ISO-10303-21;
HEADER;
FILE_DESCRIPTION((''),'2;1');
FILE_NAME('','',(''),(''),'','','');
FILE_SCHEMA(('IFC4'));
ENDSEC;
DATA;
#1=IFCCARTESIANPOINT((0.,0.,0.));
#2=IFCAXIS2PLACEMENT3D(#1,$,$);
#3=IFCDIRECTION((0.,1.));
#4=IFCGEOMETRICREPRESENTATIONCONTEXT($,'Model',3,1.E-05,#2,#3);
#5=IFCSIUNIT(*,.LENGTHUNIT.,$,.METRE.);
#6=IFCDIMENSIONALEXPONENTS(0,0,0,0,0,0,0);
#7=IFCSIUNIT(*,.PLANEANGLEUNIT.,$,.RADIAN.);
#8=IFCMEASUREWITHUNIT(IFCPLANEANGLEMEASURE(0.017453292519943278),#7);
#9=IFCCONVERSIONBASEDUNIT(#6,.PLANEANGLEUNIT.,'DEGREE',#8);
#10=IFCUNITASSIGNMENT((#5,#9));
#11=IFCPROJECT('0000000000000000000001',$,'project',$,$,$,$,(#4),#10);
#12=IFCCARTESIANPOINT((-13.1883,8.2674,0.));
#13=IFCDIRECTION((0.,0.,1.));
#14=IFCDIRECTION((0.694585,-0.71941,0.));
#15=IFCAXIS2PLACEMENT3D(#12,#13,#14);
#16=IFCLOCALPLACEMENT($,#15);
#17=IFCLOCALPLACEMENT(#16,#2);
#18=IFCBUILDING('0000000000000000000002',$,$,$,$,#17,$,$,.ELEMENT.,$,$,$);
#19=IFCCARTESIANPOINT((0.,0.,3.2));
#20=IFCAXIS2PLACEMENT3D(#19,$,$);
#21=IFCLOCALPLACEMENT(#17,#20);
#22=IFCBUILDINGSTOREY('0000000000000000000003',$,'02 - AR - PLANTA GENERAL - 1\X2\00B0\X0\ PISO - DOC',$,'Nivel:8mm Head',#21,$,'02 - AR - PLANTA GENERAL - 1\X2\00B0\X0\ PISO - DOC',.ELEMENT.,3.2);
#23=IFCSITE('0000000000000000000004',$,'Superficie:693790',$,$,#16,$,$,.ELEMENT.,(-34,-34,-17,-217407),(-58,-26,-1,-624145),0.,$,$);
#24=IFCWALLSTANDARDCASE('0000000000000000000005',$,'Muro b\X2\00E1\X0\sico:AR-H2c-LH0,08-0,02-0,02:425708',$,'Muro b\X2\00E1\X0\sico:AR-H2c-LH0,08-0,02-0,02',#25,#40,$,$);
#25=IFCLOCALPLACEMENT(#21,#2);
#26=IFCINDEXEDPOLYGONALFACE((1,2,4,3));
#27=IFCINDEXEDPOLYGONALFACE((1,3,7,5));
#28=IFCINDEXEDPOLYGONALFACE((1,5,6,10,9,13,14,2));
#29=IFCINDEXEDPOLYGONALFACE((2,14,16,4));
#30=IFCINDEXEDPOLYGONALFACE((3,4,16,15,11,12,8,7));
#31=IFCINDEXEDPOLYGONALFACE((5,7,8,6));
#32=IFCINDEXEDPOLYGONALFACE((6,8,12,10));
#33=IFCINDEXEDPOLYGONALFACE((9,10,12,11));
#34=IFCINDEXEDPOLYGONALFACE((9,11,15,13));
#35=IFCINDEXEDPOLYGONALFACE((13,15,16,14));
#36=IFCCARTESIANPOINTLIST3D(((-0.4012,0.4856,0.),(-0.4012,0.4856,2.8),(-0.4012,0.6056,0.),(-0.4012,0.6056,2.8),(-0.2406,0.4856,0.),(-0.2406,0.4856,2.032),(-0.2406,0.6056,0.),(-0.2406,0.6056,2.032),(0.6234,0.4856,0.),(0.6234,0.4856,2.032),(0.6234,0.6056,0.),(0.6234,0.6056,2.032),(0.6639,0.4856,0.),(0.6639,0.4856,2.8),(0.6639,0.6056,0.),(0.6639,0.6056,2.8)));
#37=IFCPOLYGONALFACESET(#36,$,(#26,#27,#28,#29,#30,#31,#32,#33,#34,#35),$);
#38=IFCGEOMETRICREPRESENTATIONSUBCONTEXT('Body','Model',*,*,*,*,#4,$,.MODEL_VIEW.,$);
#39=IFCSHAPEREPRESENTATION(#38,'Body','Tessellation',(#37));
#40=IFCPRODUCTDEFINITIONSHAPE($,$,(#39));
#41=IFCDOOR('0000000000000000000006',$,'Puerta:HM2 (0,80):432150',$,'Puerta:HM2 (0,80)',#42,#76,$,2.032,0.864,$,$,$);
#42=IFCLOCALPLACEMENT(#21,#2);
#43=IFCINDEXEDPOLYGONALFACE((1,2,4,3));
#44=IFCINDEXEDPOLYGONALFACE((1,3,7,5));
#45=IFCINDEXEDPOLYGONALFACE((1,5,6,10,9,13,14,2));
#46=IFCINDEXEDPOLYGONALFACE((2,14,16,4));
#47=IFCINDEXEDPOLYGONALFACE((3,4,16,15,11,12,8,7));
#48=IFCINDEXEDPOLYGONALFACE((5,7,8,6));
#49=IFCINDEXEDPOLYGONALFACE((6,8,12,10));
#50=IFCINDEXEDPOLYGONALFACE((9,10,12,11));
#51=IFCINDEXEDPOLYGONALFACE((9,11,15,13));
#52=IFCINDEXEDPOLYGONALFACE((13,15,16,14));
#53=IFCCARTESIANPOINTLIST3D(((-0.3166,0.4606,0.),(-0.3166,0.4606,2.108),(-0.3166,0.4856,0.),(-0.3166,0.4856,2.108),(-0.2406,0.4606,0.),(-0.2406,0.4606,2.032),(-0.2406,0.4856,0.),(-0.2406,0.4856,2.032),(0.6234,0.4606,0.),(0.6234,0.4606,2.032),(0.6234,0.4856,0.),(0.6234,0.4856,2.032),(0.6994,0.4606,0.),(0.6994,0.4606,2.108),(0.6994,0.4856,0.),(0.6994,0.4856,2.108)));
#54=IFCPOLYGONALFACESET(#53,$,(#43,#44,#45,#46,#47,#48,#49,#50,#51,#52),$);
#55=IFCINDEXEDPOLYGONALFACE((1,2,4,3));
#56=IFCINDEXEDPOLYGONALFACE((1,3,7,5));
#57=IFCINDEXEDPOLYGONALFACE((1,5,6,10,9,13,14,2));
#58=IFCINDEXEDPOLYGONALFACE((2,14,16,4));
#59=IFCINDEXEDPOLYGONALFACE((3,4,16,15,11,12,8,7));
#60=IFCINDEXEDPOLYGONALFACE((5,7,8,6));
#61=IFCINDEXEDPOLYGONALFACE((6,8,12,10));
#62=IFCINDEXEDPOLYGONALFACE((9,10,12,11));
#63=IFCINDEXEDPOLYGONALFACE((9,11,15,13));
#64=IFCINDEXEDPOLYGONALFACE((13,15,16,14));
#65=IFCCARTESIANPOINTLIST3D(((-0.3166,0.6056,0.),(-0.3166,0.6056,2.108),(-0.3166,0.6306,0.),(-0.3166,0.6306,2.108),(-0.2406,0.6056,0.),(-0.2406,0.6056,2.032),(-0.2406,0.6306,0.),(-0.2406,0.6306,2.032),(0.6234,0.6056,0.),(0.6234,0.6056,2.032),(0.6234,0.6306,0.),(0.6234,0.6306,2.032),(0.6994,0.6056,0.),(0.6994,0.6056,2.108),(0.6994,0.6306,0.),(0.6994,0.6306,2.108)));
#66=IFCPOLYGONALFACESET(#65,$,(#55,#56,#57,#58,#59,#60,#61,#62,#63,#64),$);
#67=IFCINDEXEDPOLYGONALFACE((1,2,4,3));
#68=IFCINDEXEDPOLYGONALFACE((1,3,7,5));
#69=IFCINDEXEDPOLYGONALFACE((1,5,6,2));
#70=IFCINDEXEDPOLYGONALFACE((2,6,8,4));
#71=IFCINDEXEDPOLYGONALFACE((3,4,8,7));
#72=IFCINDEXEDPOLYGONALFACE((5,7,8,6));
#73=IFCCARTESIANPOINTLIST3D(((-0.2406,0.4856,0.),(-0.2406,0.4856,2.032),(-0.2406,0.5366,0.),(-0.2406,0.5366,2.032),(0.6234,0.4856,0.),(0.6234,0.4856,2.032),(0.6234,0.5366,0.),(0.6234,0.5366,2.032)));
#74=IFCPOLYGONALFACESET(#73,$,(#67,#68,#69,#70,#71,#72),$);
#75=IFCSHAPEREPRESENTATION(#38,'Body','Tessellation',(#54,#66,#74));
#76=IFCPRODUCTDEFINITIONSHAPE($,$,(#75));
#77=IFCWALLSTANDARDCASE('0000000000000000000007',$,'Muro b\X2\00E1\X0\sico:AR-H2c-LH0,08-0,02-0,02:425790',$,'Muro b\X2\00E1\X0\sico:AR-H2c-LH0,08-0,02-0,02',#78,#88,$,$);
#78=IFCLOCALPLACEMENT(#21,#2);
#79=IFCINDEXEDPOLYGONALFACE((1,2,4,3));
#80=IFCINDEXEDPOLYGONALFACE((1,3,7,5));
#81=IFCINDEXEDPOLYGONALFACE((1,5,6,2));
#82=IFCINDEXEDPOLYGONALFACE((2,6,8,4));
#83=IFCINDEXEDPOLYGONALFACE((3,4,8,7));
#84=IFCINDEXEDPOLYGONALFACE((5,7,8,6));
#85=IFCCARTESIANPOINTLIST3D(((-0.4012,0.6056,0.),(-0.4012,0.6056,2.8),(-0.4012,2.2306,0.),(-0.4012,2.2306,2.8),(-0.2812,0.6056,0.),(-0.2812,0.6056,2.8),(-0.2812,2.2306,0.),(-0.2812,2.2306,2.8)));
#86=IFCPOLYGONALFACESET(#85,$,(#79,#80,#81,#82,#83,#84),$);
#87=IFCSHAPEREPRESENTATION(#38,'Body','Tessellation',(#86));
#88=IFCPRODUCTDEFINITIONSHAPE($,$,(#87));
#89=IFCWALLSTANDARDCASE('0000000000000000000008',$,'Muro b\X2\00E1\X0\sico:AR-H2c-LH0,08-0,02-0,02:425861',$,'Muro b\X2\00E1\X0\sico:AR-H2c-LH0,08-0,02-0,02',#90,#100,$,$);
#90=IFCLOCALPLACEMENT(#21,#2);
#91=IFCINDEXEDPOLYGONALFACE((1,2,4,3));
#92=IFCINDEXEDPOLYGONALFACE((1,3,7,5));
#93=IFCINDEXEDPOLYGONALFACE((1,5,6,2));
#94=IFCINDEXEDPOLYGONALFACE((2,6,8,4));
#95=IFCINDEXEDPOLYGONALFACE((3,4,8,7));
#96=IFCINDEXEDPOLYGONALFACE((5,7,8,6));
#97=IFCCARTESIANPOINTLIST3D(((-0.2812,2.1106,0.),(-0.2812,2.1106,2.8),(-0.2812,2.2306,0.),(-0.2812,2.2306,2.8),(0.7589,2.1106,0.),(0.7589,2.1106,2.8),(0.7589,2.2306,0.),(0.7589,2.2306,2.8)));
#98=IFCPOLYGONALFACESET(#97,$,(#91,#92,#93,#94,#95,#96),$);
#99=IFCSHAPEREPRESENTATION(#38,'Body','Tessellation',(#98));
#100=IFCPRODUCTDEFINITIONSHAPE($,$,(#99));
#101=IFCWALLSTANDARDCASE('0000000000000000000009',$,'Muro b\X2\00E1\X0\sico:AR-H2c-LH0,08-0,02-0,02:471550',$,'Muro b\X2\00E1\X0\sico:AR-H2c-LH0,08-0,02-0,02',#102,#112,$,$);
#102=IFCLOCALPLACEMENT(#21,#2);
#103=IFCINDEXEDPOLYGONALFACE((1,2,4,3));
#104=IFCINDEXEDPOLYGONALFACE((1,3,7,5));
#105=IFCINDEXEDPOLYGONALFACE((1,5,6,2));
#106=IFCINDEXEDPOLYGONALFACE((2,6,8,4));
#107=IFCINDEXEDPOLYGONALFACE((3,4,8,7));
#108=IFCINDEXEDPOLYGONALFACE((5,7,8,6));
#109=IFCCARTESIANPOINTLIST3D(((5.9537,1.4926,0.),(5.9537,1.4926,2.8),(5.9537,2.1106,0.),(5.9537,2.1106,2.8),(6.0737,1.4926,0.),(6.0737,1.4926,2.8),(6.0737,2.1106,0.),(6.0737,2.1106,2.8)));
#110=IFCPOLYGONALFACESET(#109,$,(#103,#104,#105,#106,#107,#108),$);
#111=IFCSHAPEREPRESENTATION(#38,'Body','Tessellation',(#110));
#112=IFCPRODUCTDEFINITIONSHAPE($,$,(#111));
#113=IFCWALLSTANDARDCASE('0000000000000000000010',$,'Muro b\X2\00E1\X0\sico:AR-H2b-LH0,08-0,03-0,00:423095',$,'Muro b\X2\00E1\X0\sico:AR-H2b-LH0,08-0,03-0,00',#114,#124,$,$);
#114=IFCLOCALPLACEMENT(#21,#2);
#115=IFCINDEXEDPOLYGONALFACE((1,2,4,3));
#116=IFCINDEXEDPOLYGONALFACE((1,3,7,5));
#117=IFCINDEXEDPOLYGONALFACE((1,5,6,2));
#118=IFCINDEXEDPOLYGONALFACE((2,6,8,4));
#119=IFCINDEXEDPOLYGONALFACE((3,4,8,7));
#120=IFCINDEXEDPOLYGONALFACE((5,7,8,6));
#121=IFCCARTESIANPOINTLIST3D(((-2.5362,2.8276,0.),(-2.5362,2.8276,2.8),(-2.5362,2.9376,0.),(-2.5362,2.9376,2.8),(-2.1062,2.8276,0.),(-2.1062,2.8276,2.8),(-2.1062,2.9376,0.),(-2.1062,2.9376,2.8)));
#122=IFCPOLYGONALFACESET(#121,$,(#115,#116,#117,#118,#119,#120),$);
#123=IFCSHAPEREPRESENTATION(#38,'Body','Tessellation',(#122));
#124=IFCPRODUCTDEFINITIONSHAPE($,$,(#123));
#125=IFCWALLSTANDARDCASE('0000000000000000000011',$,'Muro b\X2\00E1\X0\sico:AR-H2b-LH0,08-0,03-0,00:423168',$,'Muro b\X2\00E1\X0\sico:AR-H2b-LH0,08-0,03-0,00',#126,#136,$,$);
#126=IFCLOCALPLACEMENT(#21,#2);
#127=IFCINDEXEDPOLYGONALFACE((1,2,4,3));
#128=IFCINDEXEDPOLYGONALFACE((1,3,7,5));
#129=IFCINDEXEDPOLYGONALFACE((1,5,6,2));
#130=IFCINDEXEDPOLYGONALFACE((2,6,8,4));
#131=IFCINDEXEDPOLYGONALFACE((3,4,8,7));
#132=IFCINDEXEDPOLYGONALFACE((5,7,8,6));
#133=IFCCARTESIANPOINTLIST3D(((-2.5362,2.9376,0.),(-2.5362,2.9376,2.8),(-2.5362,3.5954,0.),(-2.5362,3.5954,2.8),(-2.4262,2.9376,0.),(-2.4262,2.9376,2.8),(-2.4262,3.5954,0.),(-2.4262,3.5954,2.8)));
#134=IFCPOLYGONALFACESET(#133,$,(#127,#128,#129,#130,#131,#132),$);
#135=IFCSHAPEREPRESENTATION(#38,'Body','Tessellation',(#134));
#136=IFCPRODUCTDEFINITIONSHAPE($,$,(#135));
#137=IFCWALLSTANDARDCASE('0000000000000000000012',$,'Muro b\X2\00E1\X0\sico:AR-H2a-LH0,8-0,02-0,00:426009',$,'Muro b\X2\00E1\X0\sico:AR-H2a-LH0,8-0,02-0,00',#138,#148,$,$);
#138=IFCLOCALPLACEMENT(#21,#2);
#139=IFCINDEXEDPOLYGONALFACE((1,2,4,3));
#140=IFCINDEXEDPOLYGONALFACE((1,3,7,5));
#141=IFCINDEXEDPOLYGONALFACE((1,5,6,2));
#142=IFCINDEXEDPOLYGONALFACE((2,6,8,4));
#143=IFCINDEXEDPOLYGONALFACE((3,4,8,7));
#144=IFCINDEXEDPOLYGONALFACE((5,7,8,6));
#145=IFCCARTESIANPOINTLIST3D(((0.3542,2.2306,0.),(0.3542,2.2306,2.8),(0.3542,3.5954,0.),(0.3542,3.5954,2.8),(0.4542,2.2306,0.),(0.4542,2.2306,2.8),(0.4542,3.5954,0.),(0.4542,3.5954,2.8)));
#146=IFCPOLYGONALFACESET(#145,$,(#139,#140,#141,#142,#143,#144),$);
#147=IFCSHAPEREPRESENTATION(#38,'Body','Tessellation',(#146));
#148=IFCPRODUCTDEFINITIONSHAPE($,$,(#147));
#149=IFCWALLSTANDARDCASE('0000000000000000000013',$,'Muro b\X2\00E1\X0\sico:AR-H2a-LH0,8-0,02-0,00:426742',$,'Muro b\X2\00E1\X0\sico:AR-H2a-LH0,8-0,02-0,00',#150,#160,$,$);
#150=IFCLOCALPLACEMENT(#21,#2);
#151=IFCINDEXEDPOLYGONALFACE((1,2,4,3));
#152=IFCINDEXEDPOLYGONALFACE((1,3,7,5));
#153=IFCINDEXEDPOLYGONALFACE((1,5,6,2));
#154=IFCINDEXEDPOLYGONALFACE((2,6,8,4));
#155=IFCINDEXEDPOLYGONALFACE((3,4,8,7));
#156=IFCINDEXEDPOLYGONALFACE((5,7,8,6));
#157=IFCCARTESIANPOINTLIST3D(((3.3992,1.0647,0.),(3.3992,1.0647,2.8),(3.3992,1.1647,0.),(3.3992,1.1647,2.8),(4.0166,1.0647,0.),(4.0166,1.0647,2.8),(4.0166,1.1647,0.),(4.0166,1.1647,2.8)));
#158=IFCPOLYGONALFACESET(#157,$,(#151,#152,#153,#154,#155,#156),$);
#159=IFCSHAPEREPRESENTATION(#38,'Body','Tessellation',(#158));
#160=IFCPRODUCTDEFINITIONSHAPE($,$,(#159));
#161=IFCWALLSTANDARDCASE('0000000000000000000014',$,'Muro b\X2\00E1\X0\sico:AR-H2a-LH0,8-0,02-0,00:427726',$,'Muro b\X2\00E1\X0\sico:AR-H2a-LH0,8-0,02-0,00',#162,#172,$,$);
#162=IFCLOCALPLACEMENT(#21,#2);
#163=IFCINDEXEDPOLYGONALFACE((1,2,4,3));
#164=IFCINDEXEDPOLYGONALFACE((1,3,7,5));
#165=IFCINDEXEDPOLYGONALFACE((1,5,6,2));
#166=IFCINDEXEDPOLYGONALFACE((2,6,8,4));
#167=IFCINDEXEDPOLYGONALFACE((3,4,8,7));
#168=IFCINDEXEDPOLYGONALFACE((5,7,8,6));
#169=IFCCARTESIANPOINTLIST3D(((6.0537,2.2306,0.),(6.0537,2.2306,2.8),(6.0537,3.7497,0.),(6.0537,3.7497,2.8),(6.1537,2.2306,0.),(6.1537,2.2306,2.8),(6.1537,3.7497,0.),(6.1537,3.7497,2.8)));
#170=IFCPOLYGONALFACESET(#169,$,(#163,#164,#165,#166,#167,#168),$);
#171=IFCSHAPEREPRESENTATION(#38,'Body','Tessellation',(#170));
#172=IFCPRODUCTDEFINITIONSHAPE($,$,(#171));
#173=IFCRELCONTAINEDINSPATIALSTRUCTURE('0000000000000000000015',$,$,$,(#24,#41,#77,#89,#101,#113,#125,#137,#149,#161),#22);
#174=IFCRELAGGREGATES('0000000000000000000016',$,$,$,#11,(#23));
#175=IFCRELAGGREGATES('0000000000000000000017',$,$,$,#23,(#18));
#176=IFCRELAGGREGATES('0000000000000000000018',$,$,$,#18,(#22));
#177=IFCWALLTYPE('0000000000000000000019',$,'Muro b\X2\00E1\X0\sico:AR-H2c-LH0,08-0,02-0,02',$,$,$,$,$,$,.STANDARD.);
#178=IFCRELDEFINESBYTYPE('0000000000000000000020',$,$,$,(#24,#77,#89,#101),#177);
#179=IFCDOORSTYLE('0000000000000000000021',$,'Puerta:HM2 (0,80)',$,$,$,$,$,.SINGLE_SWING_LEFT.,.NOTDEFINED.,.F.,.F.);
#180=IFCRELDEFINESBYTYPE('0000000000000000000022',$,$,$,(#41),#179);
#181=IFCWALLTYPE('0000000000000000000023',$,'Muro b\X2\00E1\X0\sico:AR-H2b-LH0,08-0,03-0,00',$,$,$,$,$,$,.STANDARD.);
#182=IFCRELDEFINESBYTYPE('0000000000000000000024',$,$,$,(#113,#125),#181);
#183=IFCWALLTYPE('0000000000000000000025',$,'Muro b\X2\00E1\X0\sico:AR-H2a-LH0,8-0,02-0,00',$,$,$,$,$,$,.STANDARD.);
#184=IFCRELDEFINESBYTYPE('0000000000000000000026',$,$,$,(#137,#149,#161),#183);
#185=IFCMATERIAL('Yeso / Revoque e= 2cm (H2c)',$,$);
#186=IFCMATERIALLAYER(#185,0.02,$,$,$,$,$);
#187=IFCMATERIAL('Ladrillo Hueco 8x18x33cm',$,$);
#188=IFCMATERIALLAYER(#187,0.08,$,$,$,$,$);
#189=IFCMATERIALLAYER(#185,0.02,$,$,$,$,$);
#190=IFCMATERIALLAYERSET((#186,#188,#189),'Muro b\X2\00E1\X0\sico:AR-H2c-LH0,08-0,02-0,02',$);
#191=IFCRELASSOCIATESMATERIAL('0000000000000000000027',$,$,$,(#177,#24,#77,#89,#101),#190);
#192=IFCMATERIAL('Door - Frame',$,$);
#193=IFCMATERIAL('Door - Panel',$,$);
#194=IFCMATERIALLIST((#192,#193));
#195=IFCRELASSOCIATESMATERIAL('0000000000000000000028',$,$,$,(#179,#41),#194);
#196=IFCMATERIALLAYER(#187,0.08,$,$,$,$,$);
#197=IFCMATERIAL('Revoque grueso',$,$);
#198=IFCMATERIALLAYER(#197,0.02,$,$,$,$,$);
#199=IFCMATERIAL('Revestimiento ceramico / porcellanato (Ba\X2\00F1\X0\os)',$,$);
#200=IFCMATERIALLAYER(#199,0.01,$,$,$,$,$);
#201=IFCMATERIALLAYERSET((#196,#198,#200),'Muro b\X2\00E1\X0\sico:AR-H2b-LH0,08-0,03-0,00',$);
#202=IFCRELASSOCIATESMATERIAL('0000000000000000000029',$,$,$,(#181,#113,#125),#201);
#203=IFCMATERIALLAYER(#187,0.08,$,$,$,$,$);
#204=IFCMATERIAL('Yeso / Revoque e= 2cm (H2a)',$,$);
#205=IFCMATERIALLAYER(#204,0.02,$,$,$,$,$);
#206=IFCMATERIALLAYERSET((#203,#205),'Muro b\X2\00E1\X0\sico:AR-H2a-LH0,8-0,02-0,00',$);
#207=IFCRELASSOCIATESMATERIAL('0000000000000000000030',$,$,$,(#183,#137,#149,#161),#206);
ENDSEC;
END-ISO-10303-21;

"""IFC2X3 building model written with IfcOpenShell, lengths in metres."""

from ifc_helpers import new_model, entity, si_unit, converted_unit, direction, frame, frame_2d, origin, origin_2d_with_axis, place, context, subcontext, project, spatial, polyline, rectangle, outline, extrude, source, transform, mapped, material, material_list, layer, layer_set, layer_usage, type_object, type_shapes, element, fill, save


model = new_model("IFC2X3")

# Units and contexts
model_context = context("Model", 3, precision=1e-05, world=origin(), true_north=direction((0.0, 1.0)))
body_context = subcontext(model_context, "Body", "Model", "MODEL_VIEW")
ifc_project = project(units=[si_unit("LENGTHUNIT", "METRE"), converted_unit("PLANEANGLEUNIT", "DEGREE", entity("IfcPlaneAngleMeasure", 0.017453292519943278), si_unit("PLANEANGLEUNIT", "RADIAN"), dimensions=[0, 0, 0, 0, 0, 0, 0])], contexts=[model_context])

# Site, building, storey
site_placement = place(None, frame((-13.1883, 8.2674, 0.0), z_axis=(0.0, 0.0, 1.0), x_axis=(0.694585, -0.71941, 0.0)))
site = spatial("IfcSite", under=ifc_project, at=site_placement, Name="Superficie:693790", CompositionType="ELEMENT", RefLatitude=(-34, -34, -17, -217407), RefLongitude=(-58, -26, -1, -624145), RefElevation=0.0)
building_placement = place(site_placement, origin())
building = spatial("IfcBuilding", under=site, at=building_placement, CompositionType="ELEMENT")
storey_placement = place(building_placement, frame((0.0, 0.0, 3.2)))
storey = spatial("IfcBuildingStorey", under=building, at=storey_placement, Name="02 - AR - PLANTA GENERAL - 1° PISO - DOC", ObjectType="Nivel:8mm Head", LongName="02 - AR - PLANTA GENERAL - 1° PISO - DOC", CompositionType="ELEMENT", Elevation=3.2)

# Wall, opening, door
ifc_material_1 = material(Name="Yeso / Revoque e= 2cm (H2c)")
ifc_layer_1 = layer(ifc_material_1, 0.02)
ifc_material_2 = material(Name="Ladrillo Hueco 8x18x33cm")
ifc_layer_2 = layer(ifc_material_2, 0.08)
ifc_layer_3 = layer(ifc_material_1, 0.02)
ifc_layer_set_1 = layer_set([ifc_layer_1, ifc_layer_2, ifc_layer_3], Name="Muro básico:AR-H2c-LH0,08-0,02-0,02")
ifc_layer_usage_1 = layer_usage(ifc_layer_set_1, "AXIS2", "NEGATIVE", 0.06)
wall_type_1 = type_object("IfcWallType", Name="Muro básico:AR-H2c-LH0,08-0,02-0,02", PredefinedType="STANDARD", material=ifc_layer_set_1)
wall_1_placement = place(storey_placement, frame((0.6639, 0.5456, 0.0), z_axis=(0.0, 0.0, 1.0), x_axis=(-1.0, 0.0, 0.0)))
wall_1 = element("IfcWallStandardCase", 1, at=wall_1_placement, inside=storey, type_object=wall_type_1, material=ifc_layer_usage_1, Name="Muro básico:AR-H2c-LH0,08-0,02-0,02:425708", ObjectType="Muro básico:AR-H2c-LH0,08-0,02-0,02", context=body_context, shape_type="SweptSolid", body=[
    extrude(rectangle(XDim=1.0652, YDim=0.12, at=frame_2d((0.5326, 0.0), x_axis=(1.0, 0.0))), origin(), (0.0, 0.0, 1.0), 2.8),
])
opening_1_placement = place(wall_1_placement, frame((0.0406, -0.06, 0.0)))
opening_1 = element("IfcOpeningElement", 2, at=opening_1_placement, cuts=wall_1, ObjectType="Opening", context=body_context, shape_type="SweptSolid", body=[
    extrude(rectangle(XDim=0.864, YDim=2.032, at=frame_2d((1.016, 0.432), x_axis=(0.0, -1.0))), frame((0.0, 0.0, 0.0), z_axis=(0.0, 1.0, 0.0), x_axis=(0.0, 0.0, 1.0)), (0.0, 0.0, 1.0), 0.12),
])
ifc_material_3 = material(Name="Door - Frame")
ifc_material_4 = material(Name="Door - Panel")
ifc_material_list = material_list([ifc_material_3, ifc_material_4])
door_style = type_object("IfcDoorStyle", Name="Puerta:HM2 (0,80)", ConstructionType="NOTDEFINED", OperationType="SINGLE_SWING_LEFT", ParameterTakesPrecedence=False, Sizeable=False, material=ifc_material_list)
shared_shape_1 = source(origin(), body_context, "Body", "SweptSolid", [
    extrude(outline(polyline([(-0.508, -1.073), (0.508, -1.073), (0.508, 1.035), (0.432, 1.035), (0.432, -0.997), (-0.432, -0.997), (-0.432, 1.035), (-0.508, 1.035), (-0.508, -1.073)])), frame((0.432, 0.145, 1.035), z_axis=(0.0, -1.0, 0.0), x_axis=(-1.0, 0.0, 0.0)), (0.0, 0.0, 1.0), 0.025),
    extrude(outline(polyline([(-1.073, -0.508), (1.035, -0.508), (1.035, -0.432), (-0.997, -0.432), (-0.997, 0.432), (1.035, 0.432), (1.035, 0.508), (-1.073, 0.508), (-1.073, -0.508)])), frame((0.432, 0.0, 1.035), z_axis=(0.0, -1.0, 0.0), x_axis=(0.0, 0.0, -1.0)), (0.0, 0.0, 1.0), 0.025),
    extrude(rectangle(XDim=0.864, YDim=0.051, at=origin_2d_with_axis()), frame((0.432, 0.0945, 0.0)), (0.0, 0.0, 1.0), 2.032),
])
type_shapes(door_style, [shared_shape_1])
door_placement = place(opening_1_placement, origin())
door = element("IfcDoor", 3, at=door_placement, inside=storey, type_object=door_style, material=ifc_material_list, Name="Puerta:HM2 (0,80):432150", ObjectType="Puerta:HM2 (0,80)", OverallHeight=2.032, OverallWidth=0.864, context=body_context, shape_type="MappedRepresentation", body=[
    mapped(shared_shape_1, transform((0.0, 0.0, 0.0), scale=1.0)),
])
fill(opening_1, door)

# Walls
ifc_layer_usage_2 = layer_usage(ifc_layer_set_1, "AXIS2", "NEGATIVE", 0.06)
wall_2_placement = place(storey_placement, frame((-0.3412, 0.6056, 0.0), z_axis=(0.0, 0.0, 1.0), x_axis=(0.0, 1.0, 0.0)))
element("IfcWallStandardCase", 4, at=wall_2_placement, inside=storey, type_object=wall_type_1, material=ifc_layer_usage_2, Name="Muro básico:AR-H2c-LH0,08-0,02-0,02:425790", ObjectType="Muro básico:AR-H2c-LH0,08-0,02-0,02", context=body_context, shape_type="SweptSolid", body=[
    extrude(rectangle(XDim=1.625, YDim=0.12, at=frame_2d((0.8125, 0.0), x_axis=(-1.0, 0.0))), origin(), (0.0, 0.0, 1.0), 2.8),
])
ifc_layer_usage_3 = layer_usage(ifc_layer_set_1, "AXIS2", "NEGATIVE", 0.06)
wall_3_placement = place(storey_placement, frame((-0.2812, 2.1706, 0.0)))
element("IfcWallStandardCase", 5, at=wall_3_placement, inside=storey, type_object=wall_type_1, material=ifc_layer_usage_3, Name="Muro básico:AR-H2c-LH0,08-0,02-0,02:425861", ObjectType="Muro básico:AR-H2c-LH0,08-0,02-0,02", context=body_context, shape_type="SweptSolid", body=[
    extrude(rectangle(XDim=1.0402, YDim=0.12, at=frame_2d((0.5201, 0.0), x_axis=(-1.0, 0.0))), origin(), (0.0, 0.0, 1.0), 2.8),
])
ifc_layer_usage_4 = layer_usage(ifc_layer_set_1, "AXIS2", "POSITIVE", -0.06)
wall_4_placement = place(storey_placement, frame((6.0137, 2.1106, 0.0), z_axis=(0.0, 0.0, 1.0), x_axis=(0.0, -1.0, 0.0)))
element("IfcWallStandardCase", 6, at=wall_4_placement, inside=storey, type_object=wall_type_1, material=ifc_layer_usage_4, Name="Muro básico:AR-H2c-LH0,08-0,02-0,02:471550", ObjectType="Muro básico:AR-H2c-LH0,08-0,02-0,02", context=body_context, shape_type="SweptSolid", body=[
    extrude(rectangle(XDim=0.6179, YDim=0.12, at=frame_2d((0.309, 0.0), x_axis=(-1.0, 0.0))), origin(), (0.0, 0.0, 1.0), 2.8),
])
ifc_layer_4 = layer(ifc_material_2, 0.08)
ifc_material_5 = material(Name="Revoque grueso")
ifc_layer_5 = layer(ifc_material_5, 0.02)
ifc_material_6 = material(Name="Revestimiento ceramico / porcellanato (Baños)")
ifc_layer_6 = layer(ifc_material_6, 0.01)
ifc_layer_set_2 = layer_set([ifc_layer_4, ifc_layer_5, ifc_layer_6], Name="Muro básico:AR-H2b-LH0,08-0,03-0,00")
ifc_layer_usage_5 = layer_usage(ifc_layer_set_2, "AXIS2", "POSITIVE", -0.055)
wall_type_2 = type_object("IfcWallType", Name="Muro básico:AR-H2b-LH0,08-0,03-0,00", PredefinedType="STANDARD", material=ifc_layer_set_2)
wall_5_placement = place(storey_placement, frame((-2.1062, 2.8826, 0.0), z_axis=(0.0, 0.0, 1.0), x_axis=(-1.0, 0.0, 0.0)))
element("IfcWallStandardCase", 7, at=wall_5_placement, inside=storey, type_object=wall_type_2, material=ifc_layer_usage_5, Name="Muro básico:AR-H2b-LH0,08-0,03-0,00:423095", ObjectType="Muro básico:AR-H2b-LH0,08-0,03-0,00", context=body_context, shape_type="SweptSolid", body=[
    extrude(rectangle(XDim=0.43, YDim=0.11, at=frame_2d((0.215, 0.0), x_axis=(-1.0, 0.0))), origin(), (0.0, 0.0, 1.0), 2.8),
])
ifc_layer_usage_6 = layer_usage(ifc_layer_set_2, "AXIS2", "POSITIVE", -0.055)
wall_6_placement = place(storey_placement, frame((-2.4812, 2.9376, 0.0), z_axis=(0.0, 0.0, 1.0), x_axis=(0.0, 1.0, 0.0)))
element("IfcWallStandardCase", 8, at=wall_6_placement, inside=storey, type_object=wall_type_2, material=ifc_layer_usage_6, Name="Muro básico:AR-H2b-LH0,08-0,03-0,00:423168", ObjectType="Muro básico:AR-H2b-LH0,08-0,03-0,00", context=body_context, shape_type="SweptSolid", body=[
    extrude(rectangle(XDim=0.6578, YDim=0.11, at=frame_2d((0.3289, 0.0), x_axis=(-1.0, 0.0))), origin(), (0.0, 0.0, 1.0), 2.8),
])
ifc_layer_7 = layer(ifc_material_2, 0.08)
ifc_material_7 = material(Name="Yeso / Revoque e= 2cm (H2a)")
ifc_layer_8 = layer(ifc_material_7, 0.02)
ifc_layer_set_3 = layer_set([ifc_layer_7, ifc_layer_8], Name="Muro básico:AR-H2a-LH0,8-0,02-0,00")
ifc_layer_usage_7 = layer_usage(ifc_layer_set_3, "AXIS2", "POSITIVE", -0.05)
wall_type_3 = type_object("IfcWallType", Name="Muro básico:AR-H2a-LH0,8-0,02-0,00", PredefinedType="STANDARD", material=ifc_layer_set_3)
wall_7_placement = place(storey_placement, frame((0.4042, 2.2306, 0.0), z_axis=(0.0, 0.0, 1.0), x_axis=(0.0, 1.0, 0.0)))
element("IfcWallStandardCase", 9, at=wall_7_placement, inside=storey, type_object=wall_type_3, material=ifc_layer_usage_7, Name="Muro básico:AR-H2a-LH0,8-0,02-0,00:426009", ObjectType="Muro básico:AR-H2a-LH0,8-0,02-0,00", context=body_context, shape_type="SweptSolid", body=[
    extrude(rectangle(XDim=1.3648, YDim=0.1, at=frame_2d((0.6824, 0.0), x_axis=(-1.0, 0.0))), origin(), (0.0, 0.0, 1.0), 2.8),
])
ifc_layer_usage_8 = layer_usage(ifc_layer_set_3, "AXIS2", "POSITIVE", -0.05)
wall_8_placement = place(storey_placement, frame((4.0166, 1.1147, 0.0), z_axis=(0.0, 0.0, 1.0), x_axis=(-1.0, 0.0, 0.0)))
element("IfcWallStandardCase", 10, at=wall_8_placement, inside=storey, type_object=wall_type_3, material=ifc_layer_usage_8, Name="Muro básico:AR-H2a-LH0,8-0,02-0,00:426742", ObjectType="Muro básico:AR-H2a-LH0,8-0,02-0,00", context=body_context, shape_type="SweptSolid", body=[
    extrude(rectangle(XDim=0.6175, YDim=0.1, at=frame_2d((0.3087, 0.0), x_axis=(-1.0, 0.0))), origin(), (0.0, 0.0, 1.0), 2.8),
])
ifc_layer_usage_9 = layer_usage(ifc_layer_set_3, "AXIS2", "NEGATIVE", 0.05)
wall_9_placement = place(storey_placement, frame((6.1037, 2.2306, 0.0), z_axis=(0.0, 0.0, 1.0), x_axis=(0.0, 1.0, 0.0)))
element("IfcWallStandardCase", 11, at=wall_9_placement, inside=storey, type_object=wall_type_3, material=ifc_layer_usage_9, Name="Muro básico:AR-H2a-LH0,8-0,02-0,00:427726", ObjectType="Muro básico:AR-H2a-LH0,8-0,02-0,00", context=body_context, shape_type="SweptSolid", body=[
    extrude(rectangle(XDim=1.5191, YDim=0.1, at=frame_2d((0.7595, 0.0), x_axis=(-1.0, 0.0))), origin(), (0.0, 0.0, 1.0), 2.8),
])

save(model, "model.ifc")
